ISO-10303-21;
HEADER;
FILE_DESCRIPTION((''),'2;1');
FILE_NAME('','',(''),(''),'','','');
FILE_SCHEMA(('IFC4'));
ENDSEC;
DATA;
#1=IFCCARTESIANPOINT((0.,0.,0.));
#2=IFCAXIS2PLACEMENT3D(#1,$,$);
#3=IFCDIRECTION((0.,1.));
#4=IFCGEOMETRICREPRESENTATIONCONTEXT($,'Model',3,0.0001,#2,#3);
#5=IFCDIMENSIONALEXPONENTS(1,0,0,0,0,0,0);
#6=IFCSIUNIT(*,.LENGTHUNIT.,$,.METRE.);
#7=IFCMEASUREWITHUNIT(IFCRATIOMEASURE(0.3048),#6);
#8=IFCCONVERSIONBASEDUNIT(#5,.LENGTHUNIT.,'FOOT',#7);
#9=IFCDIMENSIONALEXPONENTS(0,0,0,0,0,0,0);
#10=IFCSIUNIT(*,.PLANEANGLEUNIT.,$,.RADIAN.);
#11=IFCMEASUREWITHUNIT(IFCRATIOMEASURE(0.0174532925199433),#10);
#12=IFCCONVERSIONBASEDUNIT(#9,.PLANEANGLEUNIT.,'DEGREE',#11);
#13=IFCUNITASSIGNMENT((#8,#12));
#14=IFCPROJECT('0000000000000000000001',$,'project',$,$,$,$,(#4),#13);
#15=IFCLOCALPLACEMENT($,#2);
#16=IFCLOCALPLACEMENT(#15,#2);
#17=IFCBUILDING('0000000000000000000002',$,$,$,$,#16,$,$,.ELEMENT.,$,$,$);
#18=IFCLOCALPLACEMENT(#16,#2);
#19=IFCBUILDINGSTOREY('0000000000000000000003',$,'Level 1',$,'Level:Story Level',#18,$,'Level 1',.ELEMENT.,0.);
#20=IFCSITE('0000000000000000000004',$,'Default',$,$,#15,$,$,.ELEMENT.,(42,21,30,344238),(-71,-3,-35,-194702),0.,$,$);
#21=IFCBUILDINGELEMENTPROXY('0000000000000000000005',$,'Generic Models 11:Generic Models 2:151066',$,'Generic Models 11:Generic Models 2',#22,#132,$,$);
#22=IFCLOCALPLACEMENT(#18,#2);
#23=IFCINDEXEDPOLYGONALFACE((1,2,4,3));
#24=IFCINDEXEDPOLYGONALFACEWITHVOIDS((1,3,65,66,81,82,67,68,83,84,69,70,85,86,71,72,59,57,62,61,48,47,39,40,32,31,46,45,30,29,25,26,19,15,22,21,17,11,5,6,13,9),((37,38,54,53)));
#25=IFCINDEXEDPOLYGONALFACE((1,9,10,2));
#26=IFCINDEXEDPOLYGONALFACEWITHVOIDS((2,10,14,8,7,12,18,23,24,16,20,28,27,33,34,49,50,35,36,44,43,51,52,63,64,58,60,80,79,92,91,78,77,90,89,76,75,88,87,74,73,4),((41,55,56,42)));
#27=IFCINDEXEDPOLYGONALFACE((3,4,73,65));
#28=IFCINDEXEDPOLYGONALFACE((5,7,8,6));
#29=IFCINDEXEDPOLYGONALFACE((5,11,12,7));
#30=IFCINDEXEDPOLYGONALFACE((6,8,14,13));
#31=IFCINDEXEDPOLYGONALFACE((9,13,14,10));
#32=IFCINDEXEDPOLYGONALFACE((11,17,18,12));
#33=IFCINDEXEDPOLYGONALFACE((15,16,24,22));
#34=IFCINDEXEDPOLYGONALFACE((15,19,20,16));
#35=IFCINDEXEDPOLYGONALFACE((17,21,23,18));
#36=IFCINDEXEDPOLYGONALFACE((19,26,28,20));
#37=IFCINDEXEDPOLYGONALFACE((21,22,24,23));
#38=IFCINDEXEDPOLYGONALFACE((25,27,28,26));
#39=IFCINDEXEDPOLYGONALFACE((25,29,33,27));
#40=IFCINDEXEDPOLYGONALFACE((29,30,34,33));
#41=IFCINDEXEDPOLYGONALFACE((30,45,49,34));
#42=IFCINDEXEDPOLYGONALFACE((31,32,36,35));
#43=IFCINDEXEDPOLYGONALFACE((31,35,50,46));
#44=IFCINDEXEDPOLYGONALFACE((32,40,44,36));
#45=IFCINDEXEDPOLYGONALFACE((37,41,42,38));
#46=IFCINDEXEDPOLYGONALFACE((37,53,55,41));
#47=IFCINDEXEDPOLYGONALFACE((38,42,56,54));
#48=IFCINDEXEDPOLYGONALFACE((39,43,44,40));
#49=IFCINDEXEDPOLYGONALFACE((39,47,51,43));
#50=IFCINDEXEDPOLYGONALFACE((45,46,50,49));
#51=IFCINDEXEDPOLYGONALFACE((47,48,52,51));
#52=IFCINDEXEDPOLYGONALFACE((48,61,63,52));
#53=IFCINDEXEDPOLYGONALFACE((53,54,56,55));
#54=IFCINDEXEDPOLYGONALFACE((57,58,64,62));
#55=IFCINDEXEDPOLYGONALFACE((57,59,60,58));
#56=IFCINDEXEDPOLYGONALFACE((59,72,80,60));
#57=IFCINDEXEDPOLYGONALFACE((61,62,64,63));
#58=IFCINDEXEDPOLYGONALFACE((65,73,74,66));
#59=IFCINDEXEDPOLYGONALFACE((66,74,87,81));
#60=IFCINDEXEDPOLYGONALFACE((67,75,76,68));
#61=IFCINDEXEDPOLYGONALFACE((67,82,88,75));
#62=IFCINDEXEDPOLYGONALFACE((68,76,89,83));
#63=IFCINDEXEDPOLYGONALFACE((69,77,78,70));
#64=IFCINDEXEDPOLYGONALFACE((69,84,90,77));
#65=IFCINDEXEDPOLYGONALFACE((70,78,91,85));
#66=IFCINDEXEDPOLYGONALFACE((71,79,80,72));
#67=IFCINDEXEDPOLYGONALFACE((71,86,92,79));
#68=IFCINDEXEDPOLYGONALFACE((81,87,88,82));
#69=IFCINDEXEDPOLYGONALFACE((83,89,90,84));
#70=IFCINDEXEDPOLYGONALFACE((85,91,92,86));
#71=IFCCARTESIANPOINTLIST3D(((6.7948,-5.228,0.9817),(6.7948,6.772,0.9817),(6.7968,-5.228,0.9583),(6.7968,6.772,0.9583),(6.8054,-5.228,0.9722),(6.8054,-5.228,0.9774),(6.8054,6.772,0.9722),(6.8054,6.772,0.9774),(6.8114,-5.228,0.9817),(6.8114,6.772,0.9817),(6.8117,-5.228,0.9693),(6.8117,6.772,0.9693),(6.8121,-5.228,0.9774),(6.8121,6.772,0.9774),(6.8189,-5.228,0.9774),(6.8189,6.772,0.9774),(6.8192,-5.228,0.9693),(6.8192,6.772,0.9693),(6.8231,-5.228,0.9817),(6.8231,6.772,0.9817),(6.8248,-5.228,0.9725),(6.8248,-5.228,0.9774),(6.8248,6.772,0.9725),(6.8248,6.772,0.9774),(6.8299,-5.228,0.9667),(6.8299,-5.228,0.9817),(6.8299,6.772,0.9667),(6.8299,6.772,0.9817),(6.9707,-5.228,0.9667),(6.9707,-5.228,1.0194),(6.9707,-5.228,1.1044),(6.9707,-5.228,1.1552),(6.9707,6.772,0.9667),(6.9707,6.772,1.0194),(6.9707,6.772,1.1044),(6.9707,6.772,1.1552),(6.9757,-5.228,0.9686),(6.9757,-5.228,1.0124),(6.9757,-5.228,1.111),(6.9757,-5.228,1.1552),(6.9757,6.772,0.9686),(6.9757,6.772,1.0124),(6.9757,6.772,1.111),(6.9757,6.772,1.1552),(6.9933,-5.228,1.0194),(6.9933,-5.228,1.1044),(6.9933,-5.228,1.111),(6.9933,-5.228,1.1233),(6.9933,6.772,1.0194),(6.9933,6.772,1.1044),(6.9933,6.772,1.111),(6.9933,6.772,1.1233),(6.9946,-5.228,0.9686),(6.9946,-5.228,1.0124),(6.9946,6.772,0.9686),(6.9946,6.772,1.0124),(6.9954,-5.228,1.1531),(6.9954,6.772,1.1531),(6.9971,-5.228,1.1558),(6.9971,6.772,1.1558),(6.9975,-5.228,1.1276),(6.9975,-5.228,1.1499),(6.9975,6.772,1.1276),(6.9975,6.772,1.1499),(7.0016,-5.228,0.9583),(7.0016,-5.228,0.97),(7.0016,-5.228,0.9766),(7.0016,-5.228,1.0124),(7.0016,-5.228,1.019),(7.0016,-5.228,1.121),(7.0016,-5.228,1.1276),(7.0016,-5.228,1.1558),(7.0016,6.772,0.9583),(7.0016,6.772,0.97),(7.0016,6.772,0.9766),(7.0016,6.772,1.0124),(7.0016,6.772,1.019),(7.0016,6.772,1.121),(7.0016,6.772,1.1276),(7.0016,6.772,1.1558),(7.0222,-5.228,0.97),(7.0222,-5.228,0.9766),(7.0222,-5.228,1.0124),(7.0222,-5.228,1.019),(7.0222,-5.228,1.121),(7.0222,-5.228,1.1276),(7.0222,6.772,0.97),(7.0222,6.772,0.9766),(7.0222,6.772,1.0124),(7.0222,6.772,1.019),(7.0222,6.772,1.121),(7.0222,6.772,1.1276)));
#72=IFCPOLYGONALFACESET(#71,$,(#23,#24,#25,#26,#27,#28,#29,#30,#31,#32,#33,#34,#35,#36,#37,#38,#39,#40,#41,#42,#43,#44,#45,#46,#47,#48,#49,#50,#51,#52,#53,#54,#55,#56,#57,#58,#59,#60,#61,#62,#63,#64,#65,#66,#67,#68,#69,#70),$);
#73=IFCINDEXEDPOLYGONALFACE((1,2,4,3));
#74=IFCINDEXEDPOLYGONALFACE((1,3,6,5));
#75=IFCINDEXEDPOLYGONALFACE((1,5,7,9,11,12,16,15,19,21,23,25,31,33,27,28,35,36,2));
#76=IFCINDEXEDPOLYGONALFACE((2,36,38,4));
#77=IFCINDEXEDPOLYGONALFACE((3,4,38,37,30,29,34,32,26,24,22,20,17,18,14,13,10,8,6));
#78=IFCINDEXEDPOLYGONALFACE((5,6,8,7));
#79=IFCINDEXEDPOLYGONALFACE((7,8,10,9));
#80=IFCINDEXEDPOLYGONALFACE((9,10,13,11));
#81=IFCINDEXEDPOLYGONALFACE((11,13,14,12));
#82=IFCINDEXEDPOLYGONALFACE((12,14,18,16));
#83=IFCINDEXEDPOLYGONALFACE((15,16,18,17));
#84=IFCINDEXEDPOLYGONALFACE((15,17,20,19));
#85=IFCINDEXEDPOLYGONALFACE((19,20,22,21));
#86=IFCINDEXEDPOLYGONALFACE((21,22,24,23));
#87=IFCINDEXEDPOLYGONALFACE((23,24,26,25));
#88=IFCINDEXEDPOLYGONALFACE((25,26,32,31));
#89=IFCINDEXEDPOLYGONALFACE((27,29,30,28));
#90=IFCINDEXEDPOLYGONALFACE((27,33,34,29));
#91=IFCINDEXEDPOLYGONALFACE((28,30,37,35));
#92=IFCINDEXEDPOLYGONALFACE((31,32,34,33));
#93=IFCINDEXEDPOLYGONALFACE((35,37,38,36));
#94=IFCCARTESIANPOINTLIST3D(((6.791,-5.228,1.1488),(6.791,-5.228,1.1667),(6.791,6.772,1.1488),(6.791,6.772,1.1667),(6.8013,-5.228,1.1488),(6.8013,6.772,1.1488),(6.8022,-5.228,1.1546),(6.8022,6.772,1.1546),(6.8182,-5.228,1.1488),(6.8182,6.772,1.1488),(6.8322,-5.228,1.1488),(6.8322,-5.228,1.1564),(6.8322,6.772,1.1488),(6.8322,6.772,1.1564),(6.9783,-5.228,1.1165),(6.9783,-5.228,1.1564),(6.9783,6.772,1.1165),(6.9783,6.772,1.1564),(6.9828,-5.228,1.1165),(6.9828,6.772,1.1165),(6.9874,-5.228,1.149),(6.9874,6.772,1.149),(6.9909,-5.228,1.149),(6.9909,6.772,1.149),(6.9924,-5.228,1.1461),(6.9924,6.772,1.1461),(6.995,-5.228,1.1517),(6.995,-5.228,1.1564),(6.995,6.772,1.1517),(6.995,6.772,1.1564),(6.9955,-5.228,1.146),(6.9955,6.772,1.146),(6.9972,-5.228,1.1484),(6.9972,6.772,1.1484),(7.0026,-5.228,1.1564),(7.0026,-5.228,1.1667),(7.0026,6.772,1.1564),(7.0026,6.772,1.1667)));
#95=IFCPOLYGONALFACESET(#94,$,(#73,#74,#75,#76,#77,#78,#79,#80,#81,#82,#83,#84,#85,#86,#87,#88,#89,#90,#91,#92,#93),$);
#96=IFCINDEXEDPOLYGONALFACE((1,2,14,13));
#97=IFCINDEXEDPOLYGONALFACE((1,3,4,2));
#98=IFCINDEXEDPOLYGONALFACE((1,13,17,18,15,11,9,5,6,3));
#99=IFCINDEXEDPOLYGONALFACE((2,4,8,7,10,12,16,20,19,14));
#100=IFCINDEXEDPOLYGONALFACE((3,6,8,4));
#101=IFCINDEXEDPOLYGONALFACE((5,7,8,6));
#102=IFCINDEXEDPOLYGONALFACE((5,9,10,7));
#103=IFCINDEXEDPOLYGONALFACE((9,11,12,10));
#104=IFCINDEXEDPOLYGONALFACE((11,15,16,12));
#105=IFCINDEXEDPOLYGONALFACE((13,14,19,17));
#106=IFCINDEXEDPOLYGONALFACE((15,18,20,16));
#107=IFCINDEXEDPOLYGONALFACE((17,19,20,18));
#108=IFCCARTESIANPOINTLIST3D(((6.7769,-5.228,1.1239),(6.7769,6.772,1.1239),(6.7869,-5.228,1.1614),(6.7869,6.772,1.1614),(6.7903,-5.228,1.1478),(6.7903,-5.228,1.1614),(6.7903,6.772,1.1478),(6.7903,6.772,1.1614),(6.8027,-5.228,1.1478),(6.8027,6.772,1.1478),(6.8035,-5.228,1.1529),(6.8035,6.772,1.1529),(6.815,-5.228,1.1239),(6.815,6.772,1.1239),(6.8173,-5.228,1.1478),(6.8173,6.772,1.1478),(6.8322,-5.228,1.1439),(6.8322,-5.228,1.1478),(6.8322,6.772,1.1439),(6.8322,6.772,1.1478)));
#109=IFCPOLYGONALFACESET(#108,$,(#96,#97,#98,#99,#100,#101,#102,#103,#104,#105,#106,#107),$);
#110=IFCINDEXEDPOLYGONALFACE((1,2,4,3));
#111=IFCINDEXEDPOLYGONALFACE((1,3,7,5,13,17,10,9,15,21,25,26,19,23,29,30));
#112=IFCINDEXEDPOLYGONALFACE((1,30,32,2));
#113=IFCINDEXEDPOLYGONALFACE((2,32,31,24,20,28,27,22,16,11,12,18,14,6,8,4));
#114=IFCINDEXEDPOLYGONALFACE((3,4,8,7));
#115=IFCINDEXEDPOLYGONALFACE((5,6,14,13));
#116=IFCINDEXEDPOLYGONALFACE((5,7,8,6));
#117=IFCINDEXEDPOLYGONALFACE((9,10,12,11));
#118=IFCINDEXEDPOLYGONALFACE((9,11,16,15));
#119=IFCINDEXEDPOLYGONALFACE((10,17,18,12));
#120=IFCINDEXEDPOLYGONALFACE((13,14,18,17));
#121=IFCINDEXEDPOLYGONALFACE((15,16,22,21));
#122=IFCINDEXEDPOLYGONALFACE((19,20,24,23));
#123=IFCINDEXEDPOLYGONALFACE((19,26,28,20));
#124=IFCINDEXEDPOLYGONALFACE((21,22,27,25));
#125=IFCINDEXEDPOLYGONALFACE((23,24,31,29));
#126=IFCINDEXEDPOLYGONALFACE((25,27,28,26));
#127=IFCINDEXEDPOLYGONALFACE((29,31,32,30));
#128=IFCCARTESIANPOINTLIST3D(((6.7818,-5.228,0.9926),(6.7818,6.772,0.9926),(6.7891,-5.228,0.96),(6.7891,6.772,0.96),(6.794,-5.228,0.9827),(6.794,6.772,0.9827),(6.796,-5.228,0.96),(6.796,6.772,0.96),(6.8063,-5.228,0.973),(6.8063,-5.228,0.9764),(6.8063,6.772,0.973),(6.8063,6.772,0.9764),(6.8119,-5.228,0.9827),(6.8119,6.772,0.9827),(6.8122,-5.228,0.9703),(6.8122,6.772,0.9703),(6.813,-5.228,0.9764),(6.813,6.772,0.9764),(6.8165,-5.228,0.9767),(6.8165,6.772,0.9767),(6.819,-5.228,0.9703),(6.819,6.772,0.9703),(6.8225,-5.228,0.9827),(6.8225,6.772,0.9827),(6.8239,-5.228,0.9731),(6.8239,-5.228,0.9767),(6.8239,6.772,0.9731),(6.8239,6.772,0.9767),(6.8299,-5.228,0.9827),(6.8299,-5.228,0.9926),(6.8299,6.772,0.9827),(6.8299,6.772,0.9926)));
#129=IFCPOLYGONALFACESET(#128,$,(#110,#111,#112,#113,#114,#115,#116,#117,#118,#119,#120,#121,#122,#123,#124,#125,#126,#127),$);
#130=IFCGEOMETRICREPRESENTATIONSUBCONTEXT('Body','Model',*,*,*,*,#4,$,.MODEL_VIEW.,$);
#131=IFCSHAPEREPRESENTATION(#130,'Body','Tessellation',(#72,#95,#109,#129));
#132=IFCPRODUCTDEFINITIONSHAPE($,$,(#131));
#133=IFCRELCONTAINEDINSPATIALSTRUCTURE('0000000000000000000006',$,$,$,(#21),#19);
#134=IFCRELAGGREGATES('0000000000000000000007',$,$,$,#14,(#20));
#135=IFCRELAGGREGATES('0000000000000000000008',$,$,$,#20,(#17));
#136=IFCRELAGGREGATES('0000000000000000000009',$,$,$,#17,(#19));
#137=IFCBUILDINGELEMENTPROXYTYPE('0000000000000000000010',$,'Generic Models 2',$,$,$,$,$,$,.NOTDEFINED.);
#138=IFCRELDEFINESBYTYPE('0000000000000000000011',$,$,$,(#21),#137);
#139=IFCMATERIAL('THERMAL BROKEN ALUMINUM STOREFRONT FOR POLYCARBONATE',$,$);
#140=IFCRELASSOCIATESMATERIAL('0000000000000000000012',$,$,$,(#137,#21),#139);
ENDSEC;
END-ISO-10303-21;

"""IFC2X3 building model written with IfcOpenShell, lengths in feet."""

from ifc_helpers import new_model, entity, si_unit, converted_unit, direction, frame, origin, place, context, subcontext, project, spatial, polyline, outline, extrude, source, transform, mapped, material, type_object, type_shapes, element, save


model = new_model("IFC2X3")

# Units and contexts
model_context = context("Model", 3, precision=0.0001, world=origin(), true_north=direction((0.0, 1.0)))
body_context = subcontext(model_context, "Body", "Model", "MODEL_VIEW")
ifc_project = project(units=[converted_unit("LENGTHUNIT", "FOOT", entity("IfcRatioMeasure", 0.3048), si_unit("LENGTHUNIT", "METRE"), dimensions=[1, 0, 0, 0, 0, 0, 0]), converted_unit("PLANEANGLEUNIT", "DEGREE", entity("IfcRatioMeasure", 0.0174532925199433), si_unit("PLANEANGLEUNIT", "RADIAN"), dimensions=[0, 0, 0, 0, 0, 0, 0])], contexts=[model_context])

# Site, building, storey
site_placement = place(None, origin())
site = spatial("IfcSite", under=ifc_project, at=site_placement, Name="Default", CompositionType="ELEMENT", RefLatitude=(42, 21, 30, 344238), RefLongitude=(-71, -3, -35, -194702), RefElevation=0.0)
building_placement = place(site_placement, origin())
building = spatial("IfcBuilding", under=site, at=building_placement, CompositionType="ELEMENT")
storey_placement = place(building_placement, origin())
storey = spatial("IfcBuildingStorey", under=building, at=storey_placement, Name="Level 1", ObjectType="Level:Story Level", LongName="Level 1", CompositionType="ELEMENT", Elevation=0.0)

# Building element proxy
ifc_material = material(Name="THERMAL BROKEN ALUMINUM STOREFRONT FOR POLYCARBONATE")
building_element_proxy_type_1 = type_object("IfcBuildingElementProxyType", Name="Generic Models 2", PredefinedType="NOTDEFINED", material=ifc_material)
shared_shape_1 = source(origin(), body_context, "Body", "SweptSolid", [
    extrude(outline(polyline([(-0.107, -0.073), (-0.107, -0.058), (-0.1137, -0.058), (-0.118, -0.0623), (-0.1121, -0.0623), (-0.1121, -0.0672), (-0.1177, -0.0704), (-0.1252, -0.0704), (-0.1315, -0.0675), (-0.1315, -0.0623), (-0.1248, -0.0623), (-0.1255, -0.058), (-0.142, -0.058), (-0.1401, -0.0814), (0.0647, -0.0814), (0.0647, -0.0697), (0.0853, -0.0697), (0.0853, -0.0631), (0.0647, -0.0631), (0.0647, -0.0273), (0.0853, -0.0273), (0.0853, -0.0207), (0.0647, -0.0207), (0.0647, 0.0812), (0.0853, 0.0812), (0.0853, 0.0878), (0.0647, 0.0878), (0.0647, 0.1161), (0.0603, 0.1161), (0.0585, 0.1133), (0.0606, 0.1102), (0.0606, 0.0878), (0.0564, 0.0836), (0.0564, 0.0713), (0.0389, 0.0713), (0.0389, 0.1155), (0.0338, 0.1155), (0.0338, 0.0647), (0.0564, 0.0647), (0.0564, -0.0203), (0.0338, -0.0203), (0.0338, -0.073), (-0.107, -0.073)]), holes=[polyline([(0.0577, -0.0711), (0.0389, -0.0711), (0.0389, -0.0273), (0.0577, -0.0273), (0.0577, -0.0711)])]), frame((0.0, -0.118, -0.2198), z_axis=(-1.0, 0.0, 0.0), x_axis=(0.0, -1.0, 0.0)), (0.0, 0.0, -1.0), 12.0),
    extrude(outline(polyline([(-0.0355, -0.058), (-0.0371, -0.0606), (-0.0358, -0.0632), (-0.0318, -0.063), (-0.0278, -0.0652), (-0.0315, -0.0718), (-0.0224, -0.0768), (0.0802, 0.1083), (0.0645, 0.1169), (0.0595, 0.1079), (0.0642, 0.1042), (0.0513, 0.0931), (0.0445, 0.0809), (0.0512, 0.0772), (-0.0197, -0.0506), (-0.0545, -0.0312), (-0.0567, -0.0352), (-0.0306, -0.055), (-0.0322, -0.058), (-0.0355, -0.058)])), frame((0.0, -0.1056, -0.1105), z_axis=(-1.0, 0.0, 0.0), x_axis=(0.0, 0.484974, 0.874529)), (0.0, 0.0, -1.0), 12.0),
    extrude(outline(polyline([(-0.0178, -0.0155), (-0.0144, -0.0155), (-0.0144, -0.002), (-0.0021, -0.002), (-0.0012, -0.007), (0.0126, -0.002), (0.0275, -0.002), (0.0275, 0.002), (0.0102, 0.022), (-0.0278, 0.022), (-0.0178, -0.0155)])), frame((0.0, 0.0142, -0.1136), z_axis=(1.0, 0.0, 0.0), x_axis=(0.0, -1.0, 0.0)), (0.0, 0.0, 1.0), 12.0),
    extrude(outline(polyline([(-0.0292, -0.0159), (0.0189, -0.0159), (0.0189, -0.0059), (0.0115, -0.0059), (0.0055, 0.0001), (0.0129, 0.0001), (0.0129, 0.0037), (0.008, 0.0065), (0.0012, 0.0065), (-0.0047, 0.0038), (-0.0047, 0.0004), (0.002, 0.0004), (0.0009, -0.0059), (-0.017, -0.0059), (-0.015, 0.0168), (-0.0219, 0.0168), (-0.0292, -0.0159)])), frame((0.0, 0.0079, -0.2827), z_axis=(1.0, 0.0, 0.0), x_axis=(0.0, -1.0, 0.0)), (0.0, 0.0, 1.0), 12.0),
])
type_shapes(building_element_proxy_type_1, [shared_shape_1])
proxy_1_placement = place(storey_placement, frame((6.8189, -5.228, 1.2595), z_axis=(0.0, 0.0, 1.0), x_axis=(0.0, 1.0, 0.0)))
element("IfcBuildingElementProxy", 1, at=proxy_1_placement, inside=storey, type_object=building_element_proxy_type_1, material=ifc_material, Name="Generic Models 11:Generic Models 2:151066", ObjectType="Generic Models 11:Generic Models 2", context=body_context, shape_type="MappedRepresentation", body=[
    mapped(shared_shape_1, transform((0.0, 0.0, 0.0), scale=1.0)),
])

save(model, "model.ifc")
